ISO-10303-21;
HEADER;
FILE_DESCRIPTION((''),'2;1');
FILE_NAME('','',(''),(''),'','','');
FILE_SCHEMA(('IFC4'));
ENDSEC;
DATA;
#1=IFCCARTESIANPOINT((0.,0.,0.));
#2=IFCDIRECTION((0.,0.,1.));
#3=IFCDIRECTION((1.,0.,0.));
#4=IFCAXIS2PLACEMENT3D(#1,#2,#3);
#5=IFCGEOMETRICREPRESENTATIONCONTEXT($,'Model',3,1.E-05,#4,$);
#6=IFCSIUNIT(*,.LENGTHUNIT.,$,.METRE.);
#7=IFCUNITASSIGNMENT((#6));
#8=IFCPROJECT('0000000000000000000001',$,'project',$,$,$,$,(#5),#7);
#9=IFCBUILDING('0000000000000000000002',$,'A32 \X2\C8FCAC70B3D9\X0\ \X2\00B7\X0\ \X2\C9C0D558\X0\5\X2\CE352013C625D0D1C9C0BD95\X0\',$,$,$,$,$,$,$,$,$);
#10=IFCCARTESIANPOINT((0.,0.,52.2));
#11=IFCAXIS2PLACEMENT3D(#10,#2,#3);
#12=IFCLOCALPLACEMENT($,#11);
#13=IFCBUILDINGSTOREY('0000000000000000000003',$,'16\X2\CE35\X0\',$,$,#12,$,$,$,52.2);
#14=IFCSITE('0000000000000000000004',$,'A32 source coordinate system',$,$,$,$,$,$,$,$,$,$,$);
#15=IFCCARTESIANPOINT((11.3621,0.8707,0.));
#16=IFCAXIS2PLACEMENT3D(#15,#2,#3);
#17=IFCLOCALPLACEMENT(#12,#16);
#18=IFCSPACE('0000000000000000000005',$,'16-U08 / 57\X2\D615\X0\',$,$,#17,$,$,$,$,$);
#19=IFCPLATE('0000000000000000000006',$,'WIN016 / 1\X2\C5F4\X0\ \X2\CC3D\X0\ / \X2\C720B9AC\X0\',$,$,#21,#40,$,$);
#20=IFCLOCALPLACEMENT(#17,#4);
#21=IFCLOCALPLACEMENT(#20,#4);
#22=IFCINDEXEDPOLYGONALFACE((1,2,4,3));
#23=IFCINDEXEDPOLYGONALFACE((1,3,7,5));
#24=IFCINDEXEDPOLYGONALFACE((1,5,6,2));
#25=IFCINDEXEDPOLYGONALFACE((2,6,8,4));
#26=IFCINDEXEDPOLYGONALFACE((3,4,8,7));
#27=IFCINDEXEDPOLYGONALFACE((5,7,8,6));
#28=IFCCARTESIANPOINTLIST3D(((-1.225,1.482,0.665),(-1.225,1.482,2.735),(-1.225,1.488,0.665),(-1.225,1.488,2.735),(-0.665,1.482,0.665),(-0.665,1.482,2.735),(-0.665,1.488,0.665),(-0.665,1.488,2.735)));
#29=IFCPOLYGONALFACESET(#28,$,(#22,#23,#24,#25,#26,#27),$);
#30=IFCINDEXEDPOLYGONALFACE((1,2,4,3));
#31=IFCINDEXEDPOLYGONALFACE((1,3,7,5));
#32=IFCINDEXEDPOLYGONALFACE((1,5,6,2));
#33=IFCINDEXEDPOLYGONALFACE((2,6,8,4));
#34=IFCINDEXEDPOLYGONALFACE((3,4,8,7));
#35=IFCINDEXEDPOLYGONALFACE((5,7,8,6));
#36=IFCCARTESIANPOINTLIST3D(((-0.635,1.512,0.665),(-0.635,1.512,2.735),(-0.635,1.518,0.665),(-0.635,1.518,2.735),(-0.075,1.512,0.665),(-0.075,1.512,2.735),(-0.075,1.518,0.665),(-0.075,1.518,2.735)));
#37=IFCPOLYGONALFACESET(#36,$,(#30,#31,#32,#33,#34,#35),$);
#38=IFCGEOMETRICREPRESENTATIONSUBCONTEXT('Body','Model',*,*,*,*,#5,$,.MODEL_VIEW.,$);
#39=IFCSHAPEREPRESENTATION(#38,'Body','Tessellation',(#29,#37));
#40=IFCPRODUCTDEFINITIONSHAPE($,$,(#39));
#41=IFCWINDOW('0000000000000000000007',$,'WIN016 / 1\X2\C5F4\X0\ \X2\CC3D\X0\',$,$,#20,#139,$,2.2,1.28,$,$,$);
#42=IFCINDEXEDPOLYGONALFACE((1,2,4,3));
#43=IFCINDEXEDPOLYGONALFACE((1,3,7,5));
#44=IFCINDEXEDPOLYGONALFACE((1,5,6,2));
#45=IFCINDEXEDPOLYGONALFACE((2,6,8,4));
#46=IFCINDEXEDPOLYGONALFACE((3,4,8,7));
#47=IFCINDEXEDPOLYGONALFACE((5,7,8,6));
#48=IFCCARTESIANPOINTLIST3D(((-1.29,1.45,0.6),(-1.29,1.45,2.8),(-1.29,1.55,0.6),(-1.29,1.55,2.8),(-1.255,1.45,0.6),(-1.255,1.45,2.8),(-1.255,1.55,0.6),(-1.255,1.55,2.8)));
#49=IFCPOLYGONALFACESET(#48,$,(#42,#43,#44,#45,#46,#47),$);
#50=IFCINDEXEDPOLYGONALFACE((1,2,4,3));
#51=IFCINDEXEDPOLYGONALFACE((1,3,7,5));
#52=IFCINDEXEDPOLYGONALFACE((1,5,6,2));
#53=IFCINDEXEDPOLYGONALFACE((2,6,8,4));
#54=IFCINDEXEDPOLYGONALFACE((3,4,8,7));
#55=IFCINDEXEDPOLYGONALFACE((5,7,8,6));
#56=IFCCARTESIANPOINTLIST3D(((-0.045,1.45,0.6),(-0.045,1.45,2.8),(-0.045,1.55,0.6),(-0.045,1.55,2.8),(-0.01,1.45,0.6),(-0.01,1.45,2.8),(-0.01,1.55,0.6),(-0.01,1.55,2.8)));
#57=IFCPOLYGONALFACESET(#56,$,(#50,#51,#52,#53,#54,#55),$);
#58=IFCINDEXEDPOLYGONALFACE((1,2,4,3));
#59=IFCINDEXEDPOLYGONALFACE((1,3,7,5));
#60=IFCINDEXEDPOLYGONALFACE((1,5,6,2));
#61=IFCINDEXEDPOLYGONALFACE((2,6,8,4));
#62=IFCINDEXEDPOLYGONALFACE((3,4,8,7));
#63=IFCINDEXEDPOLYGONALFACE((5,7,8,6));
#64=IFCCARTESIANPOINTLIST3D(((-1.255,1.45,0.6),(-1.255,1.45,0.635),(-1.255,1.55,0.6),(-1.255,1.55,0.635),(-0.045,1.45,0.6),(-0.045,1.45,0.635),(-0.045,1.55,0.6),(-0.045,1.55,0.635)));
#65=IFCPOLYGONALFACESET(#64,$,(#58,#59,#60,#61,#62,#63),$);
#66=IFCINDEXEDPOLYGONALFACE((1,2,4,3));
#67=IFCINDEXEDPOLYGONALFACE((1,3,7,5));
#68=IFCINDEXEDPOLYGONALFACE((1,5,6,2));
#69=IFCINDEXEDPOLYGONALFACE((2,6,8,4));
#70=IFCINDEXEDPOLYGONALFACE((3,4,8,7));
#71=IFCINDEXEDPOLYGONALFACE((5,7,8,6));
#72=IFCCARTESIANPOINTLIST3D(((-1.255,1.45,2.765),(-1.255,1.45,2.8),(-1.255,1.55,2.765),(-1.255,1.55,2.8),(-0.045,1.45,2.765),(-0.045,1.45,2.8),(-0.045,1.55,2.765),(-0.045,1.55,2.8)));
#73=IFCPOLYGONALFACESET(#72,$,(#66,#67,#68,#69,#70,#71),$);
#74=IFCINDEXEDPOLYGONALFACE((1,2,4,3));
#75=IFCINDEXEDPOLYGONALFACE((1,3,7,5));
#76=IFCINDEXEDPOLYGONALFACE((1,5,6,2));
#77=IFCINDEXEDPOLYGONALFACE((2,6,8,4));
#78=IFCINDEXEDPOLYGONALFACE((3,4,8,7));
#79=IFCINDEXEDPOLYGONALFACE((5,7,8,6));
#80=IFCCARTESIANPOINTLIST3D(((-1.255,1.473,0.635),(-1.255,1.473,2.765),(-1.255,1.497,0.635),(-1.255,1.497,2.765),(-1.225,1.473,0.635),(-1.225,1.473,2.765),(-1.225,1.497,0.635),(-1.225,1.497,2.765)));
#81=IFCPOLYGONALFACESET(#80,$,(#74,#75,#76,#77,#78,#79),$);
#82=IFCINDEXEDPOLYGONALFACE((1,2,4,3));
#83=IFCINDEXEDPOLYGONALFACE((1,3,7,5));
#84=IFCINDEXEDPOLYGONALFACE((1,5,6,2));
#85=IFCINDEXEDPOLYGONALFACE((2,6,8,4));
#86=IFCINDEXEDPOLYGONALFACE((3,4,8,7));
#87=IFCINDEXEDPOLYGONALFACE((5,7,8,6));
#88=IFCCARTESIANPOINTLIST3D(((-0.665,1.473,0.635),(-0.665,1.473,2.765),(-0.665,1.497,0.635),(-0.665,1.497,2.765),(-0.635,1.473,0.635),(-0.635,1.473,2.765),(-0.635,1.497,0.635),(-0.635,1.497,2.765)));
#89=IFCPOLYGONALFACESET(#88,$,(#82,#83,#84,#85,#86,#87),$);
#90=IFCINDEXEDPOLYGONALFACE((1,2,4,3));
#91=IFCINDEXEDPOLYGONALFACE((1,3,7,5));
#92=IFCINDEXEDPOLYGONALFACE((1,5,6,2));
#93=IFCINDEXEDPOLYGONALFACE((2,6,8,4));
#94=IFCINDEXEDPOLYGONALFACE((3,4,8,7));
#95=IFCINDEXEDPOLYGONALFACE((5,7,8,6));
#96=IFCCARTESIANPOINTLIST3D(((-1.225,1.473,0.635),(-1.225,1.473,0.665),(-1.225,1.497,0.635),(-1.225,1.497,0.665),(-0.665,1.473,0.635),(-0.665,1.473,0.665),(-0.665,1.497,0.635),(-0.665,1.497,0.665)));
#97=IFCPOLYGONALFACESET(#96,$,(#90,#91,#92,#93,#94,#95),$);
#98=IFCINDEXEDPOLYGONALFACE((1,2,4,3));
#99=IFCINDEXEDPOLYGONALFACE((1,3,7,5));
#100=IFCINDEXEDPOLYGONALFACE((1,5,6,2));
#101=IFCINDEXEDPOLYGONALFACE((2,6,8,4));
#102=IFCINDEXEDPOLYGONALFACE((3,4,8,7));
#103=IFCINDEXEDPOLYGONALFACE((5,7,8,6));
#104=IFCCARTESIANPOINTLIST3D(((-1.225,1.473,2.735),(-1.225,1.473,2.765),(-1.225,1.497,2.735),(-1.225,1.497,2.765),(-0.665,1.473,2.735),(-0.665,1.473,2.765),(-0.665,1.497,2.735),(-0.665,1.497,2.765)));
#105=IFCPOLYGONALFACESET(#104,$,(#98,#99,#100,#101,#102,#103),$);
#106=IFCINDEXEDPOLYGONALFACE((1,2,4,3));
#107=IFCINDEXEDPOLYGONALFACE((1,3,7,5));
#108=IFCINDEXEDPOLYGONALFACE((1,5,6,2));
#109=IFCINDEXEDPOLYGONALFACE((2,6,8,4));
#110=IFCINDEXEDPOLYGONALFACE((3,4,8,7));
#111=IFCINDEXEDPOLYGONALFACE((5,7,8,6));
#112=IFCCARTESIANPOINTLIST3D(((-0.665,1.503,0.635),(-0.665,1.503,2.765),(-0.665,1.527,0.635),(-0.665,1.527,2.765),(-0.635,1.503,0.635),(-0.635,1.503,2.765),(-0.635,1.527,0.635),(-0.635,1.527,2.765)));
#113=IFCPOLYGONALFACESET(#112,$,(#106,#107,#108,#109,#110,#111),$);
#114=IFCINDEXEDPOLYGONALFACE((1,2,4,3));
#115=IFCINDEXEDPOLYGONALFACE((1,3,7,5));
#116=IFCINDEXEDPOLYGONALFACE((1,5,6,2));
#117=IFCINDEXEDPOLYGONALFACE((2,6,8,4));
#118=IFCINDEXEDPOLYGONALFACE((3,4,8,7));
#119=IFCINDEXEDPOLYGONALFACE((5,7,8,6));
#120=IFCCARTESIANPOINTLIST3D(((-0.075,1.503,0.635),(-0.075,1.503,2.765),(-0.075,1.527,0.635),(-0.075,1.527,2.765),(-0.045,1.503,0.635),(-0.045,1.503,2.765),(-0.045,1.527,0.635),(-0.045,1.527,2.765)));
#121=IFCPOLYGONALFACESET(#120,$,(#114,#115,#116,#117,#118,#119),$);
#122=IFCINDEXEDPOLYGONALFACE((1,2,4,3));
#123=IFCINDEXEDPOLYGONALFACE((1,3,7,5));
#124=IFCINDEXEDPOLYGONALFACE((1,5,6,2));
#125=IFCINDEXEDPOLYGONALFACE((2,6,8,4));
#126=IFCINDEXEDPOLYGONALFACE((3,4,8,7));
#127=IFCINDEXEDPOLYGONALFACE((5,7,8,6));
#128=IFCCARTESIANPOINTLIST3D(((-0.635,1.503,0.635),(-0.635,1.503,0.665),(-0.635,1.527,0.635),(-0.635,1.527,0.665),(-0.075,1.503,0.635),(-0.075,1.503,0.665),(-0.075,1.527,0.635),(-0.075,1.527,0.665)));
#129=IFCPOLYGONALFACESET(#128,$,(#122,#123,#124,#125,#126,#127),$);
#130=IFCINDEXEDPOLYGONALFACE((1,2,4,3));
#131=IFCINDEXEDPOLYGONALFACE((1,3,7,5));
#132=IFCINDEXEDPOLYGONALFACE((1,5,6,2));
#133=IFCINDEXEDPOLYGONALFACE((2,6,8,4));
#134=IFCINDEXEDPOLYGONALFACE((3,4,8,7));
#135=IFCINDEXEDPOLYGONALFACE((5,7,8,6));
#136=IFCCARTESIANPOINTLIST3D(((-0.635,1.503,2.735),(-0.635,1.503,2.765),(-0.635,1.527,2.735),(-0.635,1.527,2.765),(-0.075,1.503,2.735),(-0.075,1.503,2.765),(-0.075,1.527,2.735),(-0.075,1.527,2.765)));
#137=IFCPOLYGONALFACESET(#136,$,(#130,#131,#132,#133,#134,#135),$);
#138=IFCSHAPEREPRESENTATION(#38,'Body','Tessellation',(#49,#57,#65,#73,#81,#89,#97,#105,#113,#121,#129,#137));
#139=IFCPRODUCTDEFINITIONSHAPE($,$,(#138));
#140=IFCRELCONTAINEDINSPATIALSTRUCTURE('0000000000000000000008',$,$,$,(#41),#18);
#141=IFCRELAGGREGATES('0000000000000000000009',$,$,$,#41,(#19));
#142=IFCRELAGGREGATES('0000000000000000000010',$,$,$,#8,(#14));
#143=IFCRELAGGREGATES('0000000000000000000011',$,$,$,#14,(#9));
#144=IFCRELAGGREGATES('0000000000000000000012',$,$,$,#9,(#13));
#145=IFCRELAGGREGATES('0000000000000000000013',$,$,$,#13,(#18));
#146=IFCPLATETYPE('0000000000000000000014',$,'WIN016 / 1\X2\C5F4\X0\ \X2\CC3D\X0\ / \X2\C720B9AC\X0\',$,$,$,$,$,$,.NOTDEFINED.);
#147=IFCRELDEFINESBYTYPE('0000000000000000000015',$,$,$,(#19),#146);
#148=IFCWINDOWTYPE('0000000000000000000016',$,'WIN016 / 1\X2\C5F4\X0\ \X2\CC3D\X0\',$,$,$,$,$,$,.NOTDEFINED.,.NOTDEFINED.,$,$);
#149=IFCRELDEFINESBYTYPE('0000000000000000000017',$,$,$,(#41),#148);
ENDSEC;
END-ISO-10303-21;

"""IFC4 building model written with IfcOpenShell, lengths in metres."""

from ifc_helpers import new_model, si_unit, frame, origin, origin_with_axes, place, context, subcontext, project, spatial, polyline, outline, extrude, source, transform, mapped, type_object, type_shapes, element, aggregate, save


model = new_model("IFC4")

# Units and contexts
model_context = context("Model", 3, precision=1e-05, world=origin_with_axes())
body_context = subcontext(model_context, "Body", "Model", "MODEL_VIEW")
ifc_project = project(units=[si_unit("LENGTHUNIT", "METRE")], contexts=[model_context])

# Plate
storey_placement = place(None, frame((0.0, 0.0, 52.2), z_axis=(0.0, 0.0, 1.0), x_axis=(1.0, 0.0, 0.0)))
space_placement = place(storey_placement, frame((11.3621, 0.8707, 0.0), z_axis=(0.0, 0.0, 1.0), x_axis=(1.0, 0.0, 0.0)))
plate_type_1 = type_object("IfcPlateType", Name="WIN016 / 1열 창 / 유리", PredefinedType="NOTDEFINED")
shared_shape_1 = source(origin(), body_context, "Body", "SweptSolid", [
    extrude(outline(polyline([(-1.225, 1.482), (-1.225, 1.488), (-0.665, 1.488), (-0.665, 1.482), (-1.225, 1.482)])), frame((0.0, 0.0, 0.665)), (0.0, 0.0, 1.0), 2.07),
    extrude(outline(polyline([(-0.635, 1.512), (-0.635, 1.518), (-0.075, 1.518), (-0.075, 1.512), (-0.635, 1.512)])), frame((0.0, 0.0, 0.665)), (0.0, 0.0, 1.0), 2.07),
])
type_shapes(plate_type_1, [shared_shape_1])
window_1_placement = place(space_placement, origin_with_axes())
plate_1_placement = place(window_1_placement, origin_with_axes())
plate_1 = element("IfcPlate", 1, at=plate_1_placement, type_object=plate_type_1, Name="WIN016 / 1열 창 / 유리", context=body_context, shape_type="MappedRepresentation", body=[
    mapped(shared_shape_1, transform((0.0, 0.0, 0.0), scale=1.0)),
])

# Site, building, storey, space
site = spatial("IfcSite", under=ifc_project, Name="A32 source coordinate system")
building = spatial("IfcBuilding", under=site, Name="A32 주거동 · 지하5층–옥탑지붕")
storey = spatial("IfcBuildingStorey", under=building, at=storey_placement, Name="16층", Elevation=52.2)
space = spatial("IfcSpace", under=storey, at=space_placement, Name="16-U08 / 57형")

# Window
window_type_1 = type_object("IfcWindowType", Name="WIN016 / 1열 창", PartitioningType="NOTDEFINED", PredefinedType="NOTDEFINED")
shared_shape_2 = source(origin(), body_context, "Body", "SweptSolid", [
    extrude(outline(polyline([(-1.29, 1.45), (-1.29, 1.55), (-1.255, 1.55), (-1.255, 1.45), (-1.29, 1.45)])), frame((0.0, 0.0, 0.6)), (0.0, 0.0, 1.0), 2.2),
    extrude(outline(polyline([(-0.045, 1.45), (-0.045, 1.55), (-0.01, 1.55), (-0.01, 1.45), (-0.045, 1.45)])), frame((0.0, 0.0, 0.6)), (0.0, 0.0, 1.0), 2.2),
    extrude(outline(polyline([(-1.255, 1.45), (-1.255, 1.55), (-0.045, 1.55), (-0.045, 1.45), (-1.255, 1.45)])), frame((0.0, 0.0, 0.6)), (0.0, 0.0, 1.0), 0.035),
    extrude(outline(polyline([(-1.255, 1.45), (-1.255, 1.55), (-0.045, 1.55), (-0.045, 1.45), (-1.255, 1.45)])), frame((0.0, 0.0, 2.765)), (0.0, 0.0, 1.0), 0.035),
    extrude(outline(polyline([(-1.255, 1.473), (-1.255, 1.497), (-1.225, 1.497), (-1.225, 1.473), (-1.255, 1.473)])), frame((0.0, 0.0, 0.635)), (0.0, 0.0, 1.0), 2.13),
    extrude(outline(polyline([(-0.665, 1.473), (-0.665, 1.497), (-0.635, 1.497), (-0.635, 1.473), (-0.665, 1.473)])), frame((0.0, 0.0, 0.635)), (0.0, 0.0, 1.0), 2.13),
    extrude(outline(polyline([(-1.225, 1.473), (-1.225, 1.497), (-0.665, 1.497), (-0.665, 1.473), (-1.225, 1.473)])), frame((0.0, 0.0, 0.635)), (0.0, 0.0, 1.0), 0.03),
    extrude(outline(polyline([(-1.225, 1.473), (-1.225, 1.497), (-0.665, 1.497), (-0.665, 1.473), (-1.225, 1.473)])), frame((0.0, 0.0, 2.735)), (0.0, 0.0, 1.0), 0.03),
    extrude(outline(polyline([(-0.665, 1.503), (-0.665, 1.527), (-0.635, 1.527), (-0.635, 1.503), (-0.665, 1.503)])), frame((0.0, 0.0, 0.635)), (0.0, 0.0, 1.0), 2.13),
    extrude(outline(polyline([(-0.075, 1.503), (-0.075, 1.527), (-0.045, 1.527), (-0.045, 1.503), (-0.075, 1.503)])), frame((0.0, 0.0, 0.635)), (0.0, 0.0, 1.0), 2.13),
    extrude(outline(polyline([(-0.635, 1.503), (-0.635, 1.527), (-0.075, 1.527), (-0.075, 1.503), (-0.635, 1.503)])), frame((0.0, 0.0, 0.635)), (0.0, 0.0, 1.0), 0.03),
    extrude(outline(polyline([(-0.635, 1.503), (-0.635, 1.527), (-0.075, 1.527), (-0.075, 1.503), (-0.635, 1.503)])), frame((0.0, 0.0, 2.735)), (0.0, 0.0, 1.0), 0.03),
])
type_shapes(window_type_1, [shared_shape_2])
window_1 = element("IfcWindow", 2, at=window_1_placement, inside=space, type_object=window_type_1, Name="WIN016 / 1열 창", OverallHeight=2.2, OverallWidth=1.28, context=body_context, shape_type="MappedRepresentation", body=[
    mapped(shared_shape_2, transform((0.0, 0.0, 0.0), scale=1.0)),
])
aggregate(window_1, [plate_1])

save(model, "model.ifc")
